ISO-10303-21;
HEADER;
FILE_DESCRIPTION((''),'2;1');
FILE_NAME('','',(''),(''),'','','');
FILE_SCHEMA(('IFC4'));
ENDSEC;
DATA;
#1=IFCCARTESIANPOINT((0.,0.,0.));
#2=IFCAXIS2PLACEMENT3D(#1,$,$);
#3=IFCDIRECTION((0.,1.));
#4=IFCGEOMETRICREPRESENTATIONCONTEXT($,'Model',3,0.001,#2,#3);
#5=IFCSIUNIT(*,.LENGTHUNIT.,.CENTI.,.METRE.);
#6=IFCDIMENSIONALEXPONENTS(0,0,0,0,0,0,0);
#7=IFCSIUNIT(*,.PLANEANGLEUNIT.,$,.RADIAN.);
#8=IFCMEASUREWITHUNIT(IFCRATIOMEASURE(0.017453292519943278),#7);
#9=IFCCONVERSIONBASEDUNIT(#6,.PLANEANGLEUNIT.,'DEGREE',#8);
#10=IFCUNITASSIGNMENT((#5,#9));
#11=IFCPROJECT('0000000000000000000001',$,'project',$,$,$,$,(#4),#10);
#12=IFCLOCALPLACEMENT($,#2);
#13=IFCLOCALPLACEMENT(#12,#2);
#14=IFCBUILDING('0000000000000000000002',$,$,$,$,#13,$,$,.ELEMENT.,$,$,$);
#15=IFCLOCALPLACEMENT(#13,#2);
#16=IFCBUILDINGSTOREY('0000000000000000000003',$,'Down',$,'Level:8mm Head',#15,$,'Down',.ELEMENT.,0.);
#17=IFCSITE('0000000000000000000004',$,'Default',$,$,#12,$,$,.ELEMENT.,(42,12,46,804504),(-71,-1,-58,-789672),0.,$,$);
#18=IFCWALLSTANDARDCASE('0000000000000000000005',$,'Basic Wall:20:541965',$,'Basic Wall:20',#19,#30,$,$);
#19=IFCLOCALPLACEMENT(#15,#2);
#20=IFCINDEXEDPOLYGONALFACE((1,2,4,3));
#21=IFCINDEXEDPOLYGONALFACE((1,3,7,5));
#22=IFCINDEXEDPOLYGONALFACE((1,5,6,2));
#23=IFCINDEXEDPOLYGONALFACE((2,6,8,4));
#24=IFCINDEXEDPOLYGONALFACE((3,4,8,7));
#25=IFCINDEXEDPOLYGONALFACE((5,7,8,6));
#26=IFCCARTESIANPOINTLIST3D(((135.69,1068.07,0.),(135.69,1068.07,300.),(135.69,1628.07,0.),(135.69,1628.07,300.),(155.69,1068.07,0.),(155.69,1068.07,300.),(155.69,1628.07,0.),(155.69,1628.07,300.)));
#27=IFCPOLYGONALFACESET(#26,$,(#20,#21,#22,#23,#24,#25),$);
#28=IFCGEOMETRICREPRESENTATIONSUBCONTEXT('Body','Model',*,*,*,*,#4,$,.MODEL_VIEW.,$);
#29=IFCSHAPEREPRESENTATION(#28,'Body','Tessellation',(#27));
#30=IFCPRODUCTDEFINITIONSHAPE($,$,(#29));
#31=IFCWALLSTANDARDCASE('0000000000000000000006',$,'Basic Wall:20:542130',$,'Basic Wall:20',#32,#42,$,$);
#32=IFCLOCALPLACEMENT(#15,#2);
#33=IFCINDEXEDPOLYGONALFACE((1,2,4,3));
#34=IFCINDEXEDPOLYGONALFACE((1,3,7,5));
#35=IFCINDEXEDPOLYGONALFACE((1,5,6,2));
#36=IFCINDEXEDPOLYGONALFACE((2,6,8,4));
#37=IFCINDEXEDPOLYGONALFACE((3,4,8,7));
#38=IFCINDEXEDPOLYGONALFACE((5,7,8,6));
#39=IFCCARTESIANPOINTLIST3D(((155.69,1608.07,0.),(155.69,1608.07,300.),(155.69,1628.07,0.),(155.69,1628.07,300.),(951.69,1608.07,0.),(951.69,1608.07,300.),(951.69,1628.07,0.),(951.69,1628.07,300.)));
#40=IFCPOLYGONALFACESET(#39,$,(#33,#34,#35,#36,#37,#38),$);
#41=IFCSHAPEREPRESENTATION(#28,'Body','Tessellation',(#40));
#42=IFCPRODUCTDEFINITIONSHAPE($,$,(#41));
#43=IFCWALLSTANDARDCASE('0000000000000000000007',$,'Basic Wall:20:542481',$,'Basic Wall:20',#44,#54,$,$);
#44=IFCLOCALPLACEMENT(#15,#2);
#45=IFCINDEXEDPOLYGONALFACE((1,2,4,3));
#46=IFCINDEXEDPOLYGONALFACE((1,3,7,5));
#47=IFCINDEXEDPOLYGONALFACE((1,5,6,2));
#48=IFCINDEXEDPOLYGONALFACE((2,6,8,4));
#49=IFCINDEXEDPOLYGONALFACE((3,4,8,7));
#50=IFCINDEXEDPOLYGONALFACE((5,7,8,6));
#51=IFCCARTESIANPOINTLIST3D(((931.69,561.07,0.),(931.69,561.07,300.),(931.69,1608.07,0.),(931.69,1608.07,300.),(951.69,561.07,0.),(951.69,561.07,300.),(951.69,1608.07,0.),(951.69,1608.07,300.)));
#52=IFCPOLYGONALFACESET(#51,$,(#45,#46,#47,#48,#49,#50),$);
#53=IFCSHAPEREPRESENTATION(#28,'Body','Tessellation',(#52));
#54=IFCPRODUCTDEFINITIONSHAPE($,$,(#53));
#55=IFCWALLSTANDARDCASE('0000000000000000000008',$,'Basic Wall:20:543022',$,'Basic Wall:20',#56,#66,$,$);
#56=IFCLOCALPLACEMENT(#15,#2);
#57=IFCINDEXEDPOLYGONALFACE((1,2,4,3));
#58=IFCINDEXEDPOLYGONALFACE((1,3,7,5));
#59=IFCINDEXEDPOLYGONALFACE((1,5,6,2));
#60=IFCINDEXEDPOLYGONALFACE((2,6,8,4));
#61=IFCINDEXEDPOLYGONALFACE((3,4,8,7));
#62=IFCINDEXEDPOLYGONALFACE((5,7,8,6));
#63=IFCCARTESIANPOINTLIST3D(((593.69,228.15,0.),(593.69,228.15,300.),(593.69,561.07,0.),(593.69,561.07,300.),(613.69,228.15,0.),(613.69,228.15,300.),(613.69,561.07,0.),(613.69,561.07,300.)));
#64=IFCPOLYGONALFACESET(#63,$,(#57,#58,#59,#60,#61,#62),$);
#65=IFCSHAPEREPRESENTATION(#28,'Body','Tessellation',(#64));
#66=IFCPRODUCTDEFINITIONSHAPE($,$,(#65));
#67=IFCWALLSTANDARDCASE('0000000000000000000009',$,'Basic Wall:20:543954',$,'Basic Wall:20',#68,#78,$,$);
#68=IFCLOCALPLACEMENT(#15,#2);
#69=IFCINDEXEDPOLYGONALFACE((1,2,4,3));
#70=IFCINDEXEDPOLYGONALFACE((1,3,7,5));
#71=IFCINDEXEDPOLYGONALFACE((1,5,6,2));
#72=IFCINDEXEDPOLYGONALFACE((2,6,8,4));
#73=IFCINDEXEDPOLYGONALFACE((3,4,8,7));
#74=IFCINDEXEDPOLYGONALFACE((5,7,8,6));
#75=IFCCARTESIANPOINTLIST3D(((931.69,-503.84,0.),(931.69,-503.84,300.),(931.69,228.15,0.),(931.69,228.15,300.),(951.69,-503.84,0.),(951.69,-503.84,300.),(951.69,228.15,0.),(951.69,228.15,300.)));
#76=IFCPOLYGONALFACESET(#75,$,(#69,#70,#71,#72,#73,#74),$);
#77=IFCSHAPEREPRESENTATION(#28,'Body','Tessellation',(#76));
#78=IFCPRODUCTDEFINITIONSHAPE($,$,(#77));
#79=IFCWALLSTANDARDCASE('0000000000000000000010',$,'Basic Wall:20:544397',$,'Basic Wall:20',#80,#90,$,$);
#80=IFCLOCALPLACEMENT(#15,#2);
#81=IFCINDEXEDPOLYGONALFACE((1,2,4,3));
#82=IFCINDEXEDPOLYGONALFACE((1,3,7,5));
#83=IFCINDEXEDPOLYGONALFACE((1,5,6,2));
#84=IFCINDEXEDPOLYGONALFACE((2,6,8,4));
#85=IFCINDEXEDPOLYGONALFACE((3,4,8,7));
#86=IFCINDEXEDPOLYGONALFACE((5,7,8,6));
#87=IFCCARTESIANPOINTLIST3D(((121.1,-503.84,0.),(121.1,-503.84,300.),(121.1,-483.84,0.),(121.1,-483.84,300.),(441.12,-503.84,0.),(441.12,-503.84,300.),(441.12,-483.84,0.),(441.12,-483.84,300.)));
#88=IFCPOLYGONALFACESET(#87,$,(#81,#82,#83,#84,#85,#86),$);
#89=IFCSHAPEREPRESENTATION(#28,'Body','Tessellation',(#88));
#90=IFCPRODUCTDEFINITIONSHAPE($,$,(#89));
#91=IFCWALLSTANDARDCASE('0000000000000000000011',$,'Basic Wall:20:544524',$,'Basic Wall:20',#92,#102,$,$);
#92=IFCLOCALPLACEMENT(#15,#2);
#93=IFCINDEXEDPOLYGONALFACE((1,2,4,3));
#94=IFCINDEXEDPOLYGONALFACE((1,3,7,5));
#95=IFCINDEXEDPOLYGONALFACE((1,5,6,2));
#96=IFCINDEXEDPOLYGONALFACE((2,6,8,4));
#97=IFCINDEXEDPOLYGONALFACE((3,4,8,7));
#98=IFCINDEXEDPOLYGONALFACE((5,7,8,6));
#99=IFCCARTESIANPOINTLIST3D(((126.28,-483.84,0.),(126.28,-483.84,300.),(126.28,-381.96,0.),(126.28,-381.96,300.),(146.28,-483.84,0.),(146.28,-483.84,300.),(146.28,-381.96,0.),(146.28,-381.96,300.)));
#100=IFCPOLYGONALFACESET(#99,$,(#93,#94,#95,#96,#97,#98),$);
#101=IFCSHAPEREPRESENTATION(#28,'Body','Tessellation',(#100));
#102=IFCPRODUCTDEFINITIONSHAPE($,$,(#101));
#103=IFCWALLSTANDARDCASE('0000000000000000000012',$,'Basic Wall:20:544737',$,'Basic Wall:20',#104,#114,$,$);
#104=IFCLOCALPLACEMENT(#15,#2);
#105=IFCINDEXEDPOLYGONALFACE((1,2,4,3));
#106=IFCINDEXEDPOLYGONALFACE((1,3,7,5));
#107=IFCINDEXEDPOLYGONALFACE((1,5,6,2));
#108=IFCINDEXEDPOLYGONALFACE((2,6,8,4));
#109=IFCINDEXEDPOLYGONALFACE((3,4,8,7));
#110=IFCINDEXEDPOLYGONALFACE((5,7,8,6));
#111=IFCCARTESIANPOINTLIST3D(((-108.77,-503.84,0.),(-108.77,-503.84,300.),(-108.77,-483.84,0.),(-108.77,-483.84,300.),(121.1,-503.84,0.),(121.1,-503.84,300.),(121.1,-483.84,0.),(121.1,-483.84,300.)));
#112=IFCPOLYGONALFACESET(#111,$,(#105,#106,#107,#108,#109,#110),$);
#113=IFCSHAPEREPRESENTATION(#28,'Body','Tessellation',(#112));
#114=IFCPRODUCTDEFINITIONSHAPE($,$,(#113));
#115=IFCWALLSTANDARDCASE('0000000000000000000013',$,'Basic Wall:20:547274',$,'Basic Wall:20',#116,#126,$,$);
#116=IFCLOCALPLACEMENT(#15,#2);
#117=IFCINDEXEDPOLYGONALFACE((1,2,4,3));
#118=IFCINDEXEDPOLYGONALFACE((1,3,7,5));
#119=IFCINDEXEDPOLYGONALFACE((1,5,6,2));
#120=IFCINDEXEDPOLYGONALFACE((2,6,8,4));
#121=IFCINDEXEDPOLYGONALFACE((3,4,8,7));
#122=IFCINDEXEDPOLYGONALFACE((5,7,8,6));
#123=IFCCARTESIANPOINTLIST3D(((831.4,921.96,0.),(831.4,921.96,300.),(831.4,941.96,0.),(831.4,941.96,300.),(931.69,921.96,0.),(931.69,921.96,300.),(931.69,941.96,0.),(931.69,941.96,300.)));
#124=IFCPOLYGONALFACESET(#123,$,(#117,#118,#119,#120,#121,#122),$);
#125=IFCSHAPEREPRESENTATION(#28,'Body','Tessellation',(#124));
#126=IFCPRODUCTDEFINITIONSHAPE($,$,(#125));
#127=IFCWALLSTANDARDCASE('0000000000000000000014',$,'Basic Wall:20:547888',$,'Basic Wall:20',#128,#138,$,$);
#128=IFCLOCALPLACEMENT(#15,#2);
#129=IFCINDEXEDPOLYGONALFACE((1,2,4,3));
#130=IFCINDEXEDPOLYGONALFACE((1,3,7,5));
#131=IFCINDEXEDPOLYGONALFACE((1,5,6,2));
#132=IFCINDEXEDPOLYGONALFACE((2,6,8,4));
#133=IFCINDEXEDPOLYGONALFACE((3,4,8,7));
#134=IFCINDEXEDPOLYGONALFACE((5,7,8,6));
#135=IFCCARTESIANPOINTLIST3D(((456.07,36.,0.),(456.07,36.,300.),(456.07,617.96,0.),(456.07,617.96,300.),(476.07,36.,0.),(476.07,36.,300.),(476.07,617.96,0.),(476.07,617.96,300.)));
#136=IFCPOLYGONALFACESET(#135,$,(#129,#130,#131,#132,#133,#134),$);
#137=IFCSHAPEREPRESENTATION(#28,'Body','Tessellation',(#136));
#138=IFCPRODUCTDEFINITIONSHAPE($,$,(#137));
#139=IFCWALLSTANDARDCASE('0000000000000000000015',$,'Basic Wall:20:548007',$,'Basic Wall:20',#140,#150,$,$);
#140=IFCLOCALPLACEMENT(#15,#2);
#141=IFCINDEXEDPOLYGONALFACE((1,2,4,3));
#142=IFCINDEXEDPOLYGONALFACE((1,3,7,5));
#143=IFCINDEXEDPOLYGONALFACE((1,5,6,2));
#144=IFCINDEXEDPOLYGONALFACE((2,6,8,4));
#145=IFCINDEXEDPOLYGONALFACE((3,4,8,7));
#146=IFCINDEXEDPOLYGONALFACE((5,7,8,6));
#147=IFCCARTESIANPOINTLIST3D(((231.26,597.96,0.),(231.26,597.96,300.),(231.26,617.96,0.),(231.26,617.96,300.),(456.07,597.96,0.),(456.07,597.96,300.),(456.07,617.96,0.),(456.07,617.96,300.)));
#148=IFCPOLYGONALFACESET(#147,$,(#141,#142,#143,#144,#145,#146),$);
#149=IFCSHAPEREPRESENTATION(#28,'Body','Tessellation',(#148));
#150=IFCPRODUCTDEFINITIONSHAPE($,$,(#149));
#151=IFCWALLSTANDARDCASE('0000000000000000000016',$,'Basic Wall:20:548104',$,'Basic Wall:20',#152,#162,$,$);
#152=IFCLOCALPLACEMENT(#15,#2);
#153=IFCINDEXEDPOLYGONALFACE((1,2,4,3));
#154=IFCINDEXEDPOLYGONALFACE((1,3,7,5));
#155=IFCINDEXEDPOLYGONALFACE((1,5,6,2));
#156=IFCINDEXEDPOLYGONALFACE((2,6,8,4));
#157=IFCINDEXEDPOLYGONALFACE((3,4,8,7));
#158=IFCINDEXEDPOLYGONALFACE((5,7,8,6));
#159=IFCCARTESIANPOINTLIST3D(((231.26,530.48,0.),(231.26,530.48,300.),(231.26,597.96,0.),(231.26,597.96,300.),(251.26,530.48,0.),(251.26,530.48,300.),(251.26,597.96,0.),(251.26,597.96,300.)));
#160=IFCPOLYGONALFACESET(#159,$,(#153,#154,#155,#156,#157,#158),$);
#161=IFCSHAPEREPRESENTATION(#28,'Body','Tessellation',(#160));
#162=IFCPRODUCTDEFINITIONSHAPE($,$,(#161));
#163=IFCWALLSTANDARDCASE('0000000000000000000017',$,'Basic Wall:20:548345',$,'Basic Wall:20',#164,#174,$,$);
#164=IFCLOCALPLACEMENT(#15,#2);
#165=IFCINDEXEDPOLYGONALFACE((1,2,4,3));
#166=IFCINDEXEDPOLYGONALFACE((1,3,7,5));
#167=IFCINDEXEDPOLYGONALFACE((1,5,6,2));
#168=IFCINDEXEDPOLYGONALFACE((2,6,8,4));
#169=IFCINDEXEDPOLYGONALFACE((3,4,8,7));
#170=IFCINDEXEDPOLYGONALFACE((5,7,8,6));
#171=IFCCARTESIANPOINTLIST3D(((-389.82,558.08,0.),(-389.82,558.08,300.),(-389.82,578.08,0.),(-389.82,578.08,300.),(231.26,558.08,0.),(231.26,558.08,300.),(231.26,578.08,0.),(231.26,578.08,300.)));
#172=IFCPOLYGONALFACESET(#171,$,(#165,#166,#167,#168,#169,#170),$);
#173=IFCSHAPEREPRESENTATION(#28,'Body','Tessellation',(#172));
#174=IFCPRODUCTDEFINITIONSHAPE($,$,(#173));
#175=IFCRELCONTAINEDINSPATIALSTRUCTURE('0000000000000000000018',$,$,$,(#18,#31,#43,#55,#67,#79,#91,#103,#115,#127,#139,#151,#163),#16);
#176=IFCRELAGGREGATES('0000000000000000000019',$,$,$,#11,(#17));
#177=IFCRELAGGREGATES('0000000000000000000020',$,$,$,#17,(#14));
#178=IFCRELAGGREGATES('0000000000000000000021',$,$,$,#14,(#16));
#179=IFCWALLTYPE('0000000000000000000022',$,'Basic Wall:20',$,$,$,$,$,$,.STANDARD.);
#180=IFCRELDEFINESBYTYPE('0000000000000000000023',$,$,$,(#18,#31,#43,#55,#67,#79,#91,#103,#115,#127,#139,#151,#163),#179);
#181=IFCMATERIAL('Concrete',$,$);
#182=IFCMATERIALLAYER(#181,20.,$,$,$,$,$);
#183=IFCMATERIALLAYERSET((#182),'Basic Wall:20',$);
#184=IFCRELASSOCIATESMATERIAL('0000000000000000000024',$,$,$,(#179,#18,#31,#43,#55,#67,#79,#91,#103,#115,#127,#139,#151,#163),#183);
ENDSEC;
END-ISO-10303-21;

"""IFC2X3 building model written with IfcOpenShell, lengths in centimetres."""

from ifc_helpers import new_model, entity, si_unit, converted_unit, direction, frame, frame_2d, origin, place, context, subcontext, project, spatial, rectangle, extrude, material, layer, layer_set, layer_usage, type_object, element, save


model = new_model("IFC2X3")

# Units and contexts
model_context = context("Model", 3, precision=0.001, world=origin(), true_north=direction((0.0, 1.0)))
body_context = subcontext(model_context, "Body", "Model", "MODEL_VIEW")
ifc_project = project(units=[si_unit("LENGTHUNIT", "METRE", prefix="CENTI"), converted_unit("PLANEANGLEUNIT", "DEGREE", entity("IfcRatioMeasure", 0.017453292519943278), si_unit("PLANEANGLEUNIT", "RADIAN"), dimensions=[0, 0, 0, 0, 0, 0, 0])], contexts=[model_context])

# Site, building, storey
site_placement = place(None, origin())
site = spatial("IfcSite", under=ifc_project, at=site_placement, Name="Default", CompositionType="ELEMENT", RefLatitude=(42, 12, 46, 804504), RefLongitude=(-71, -1, -58, -789672), RefElevation=0.0)
building_placement = place(site_placement, origin())
building = spatial("IfcBuilding", under=site, at=building_placement, CompositionType="ELEMENT")
storey_placement = place(building_placement, origin())
storey = spatial("IfcBuildingStorey", under=building, at=storey_placement, Name="Down", ObjectType="Level:8mm Head", LongName="Down", CompositionType="ELEMENT", Elevation=0.0)

# Walls
ifc_material = material(Name="Concrete")
ifc_layer_1 = layer(ifc_material, 20.0)
ifc_layer_set_1 = layer_set([ifc_layer_1], Name="Basic Wall:20")
ifc_layer_usage_1 = layer_usage(ifc_layer_set_1, "AXIS2", "POSITIVE", -10.0)
wall_type_1 = type_object("IfcWallType", Name="Basic Wall:20", PredefinedType="STANDARD", material=ifc_layer_set_1)
wall_1_placement = place(storey_placement, frame((145.69, 1068.07, 0.0), z_axis=(0.0, 0.0, 1.0), x_axis=(0.0, 1.0, 0.0)))
element("IfcWallStandardCase", 1, at=wall_1_placement, inside=storey, type_object=wall_type_1, material=ifc_layer_usage_1, Name="Basic Wall:20:541965", ObjectType="Basic Wall:20", context=body_context, shape_type="SweptSolid", body=[
    extrude(rectangle(XDim=560.0, YDim=20.0, at=frame_2d((280.0, 0.0), x_axis=(-1.0, 0.0))), origin(), (0.0, 0.0, 1.0), 300.0),
])
ifc_layer_usage_2 = layer_usage(ifc_layer_set_1, "AXIS2", "NEGATIVE", 10.0)
wall_2_placement = place(storey_placement, frame((155.69, 1618.07, 0.0)))
element("IfcWallStandardCase", 2, at=wall_2_placement, inside=storey, type_object=wall_type_1, material=ifc_layer_usage_2, Name="Basic Wall:20:542130", ObjectType="Basic Wall:20", context=body_context, shape_type="SweptSolid", body=[
    extrude(rectangle(XDim=796.0, YDim=20.0, at=frame_2d((398.0, 0.0), x_axis=(-1.0, 0.0))), origin(), (0.0, 0.0, 1.0), 300.0),
])
ifc_layer_usage_3 = layer_usage(ifc_layer_set_1, "AXIS2", "NEGATIVE", 10.0)
wall_3_placement = place(storey_placement, frame((941.69, 1608.07, 0.0), z_axis=(0.0, 0.0, 1.0), x_axis=(0.0, -1.0, 0.0)))
element("IfcWallStandardCase", 3, at=wall_3_placement, inside=storey, type_object=wall_type_1, material=ifc_layer_usage_3, Name="Basic Wall:20:542481", ObjectType="Basic Wall:20", context=body_context, shape_type="SweptSolid", body=[
    extrude(rectangle(XDim=1047.0, YDim=20.0, at=frame_2d((523.5, 0.0), x_axis=(-1.0, 0.0))), origin(), (0.0, 0.0, 1.0), 300.0),
])
ifc_layer_usage_4 = layer_usage(ifc_layer_set_1, "AXIS2", "POSITIVE", -10.0)
wall_4_placement = place(storey_placement, frame((603.69, 561.07, 0.0), z_axis=(0.0, 0.0, 1.0), x_axis=(0.0, -1.0, 0.0)))
element("IfcWallStandardCase", 4, at=wall_4_placement, inside=storey, type_object=wall_type_1, material=ifc_layer_usage_4, Name="Basic Wall:20:543022", ObjectType="Basic Wall:20", context=body_context, shape_type="SweptSolid", body=[
    extrude(rectangle(XDim=332.91, YDim=20.0, at=frame_2d((166.46, 0.0), x_axis=(-1.0, 0.0))), origin(), (0.0, 0.0, 1.0), 300.0),
])
ifc_layer_usage_5 = layer_usage(ifc_layer_set_1, "AXIS2", "NEGATIVE", 10.0)
wall_5_placement = place(storey_placement, frame((941.69, 228.15, 0.0), z_axis=(0.0, 0.0, 1.0), x_axis=(0.0, -1.0, 0.0)))
element("IfcWallStandardCase", 5, at=wall_5_placement, inside=storey, type_object=wall_type_1, material=ifc_layer_usage_5, Name="Basic Wall:20:543954", ObjectType="Basic Wall:20", context=body_context, shape_type="SweptSolid", body=[
    extrude(rectangle(XDim=732.0, YDim=20.0, at=frame_2d((366.0, 0.0), x_axis=(-1.0, 0.0))), origin(), (0.0, 0.0, 1.0), 300.0),
])
ifc_layer_usage_6 = layer_usage(ifc_layer_set_1, "AXIS2", "NEGATIVE", 10.0)
wall_6_placement = place(storey_placement, frame((441.12, -493.84, 0.0), z_axis=(0.0, 0.0, 1.0), x_axis=(-1.0, 0.0, 0.0)))
element("IfcWallStandardCase", 6, at=wall_6_placement, inside=storey, type_object=wall_type_1, material=ifc_layer_usage_6, Name="Basic Wall:20:544397", ObjectType="Basic Wall:20", context=body_context, shape_type="SweptSolid", body=[
    extrude(rectangle(XDim=320.02, YDim=20.0, at=frame_2d((160.01, 0.0), x_axis=(-1.0, 0.0))), origin(), (0.0, 0.0, 1.0), 300.0),
])
ifc_layer_usage_7 = layer_usage(ifc_layer_set_1, "AXIS2", "POSITIVE", -10.0)
wall_7_placement = place(storey_placement, frame((136.28, -483.84, 0.0), z_axis=(0.0, 0.0, 1.0), x_axis=(0.0, 1.0, 0.0)))
element("IfcWallStandardCase", 7, at=wall_7_placement, inside=storey, type_object=wall_type_1, material=ifc_layer_usage_7, Name="Basic Wall:20:544524", ObjectType="Basic Wall:20", context=body_context, shape_type="SweptSolid", body=[
    extrude(rectangle(XDim=101.88, YDim=20.0, at=frame_2d((50.94, 0.0), x_axis=(-1.0, 0.0))), origin(), (0.0, 0.0, 1.0), 300.0),
])
ifc_layer_usage_8 = layer_usage(ifc_layer_set_1, "AXIS2", "POSITIVE", -10.0)
wall_8_placement = place(storey_placement, frame((121.1, -493.84, 0.0), z_axis=(0.0, 0.0, 1.0), x_axis=(-1.0, 0.0, 0.0)))
element("IfcWallStandardCase", 8, at=wall_8_placement, inside=storey, type_object=wall_type_1, material=ifc_layer_usage_8, Name="Basic Wall:20:544737", ObjectType="Basic Wall:20", context=body_context, shape_type="SweptSolid", body=[
    extrude(rectangle(XDim=229.87, YDim=20.0, at=frame_2d((114.93, 0.0), x_axis=(-1.0, 0.0))), origin(), (0.0, 0.0, 1.0), 300.0),
])
ifc_layer_usage_9 = layer_usage(ifc_layer_set_1, "AXIS2", "POSITIVE", -10.0)
wall_9_placement = place(storey_placement, frame((931.69, 931.96, 0.0), z_axis=(0.0, 0.0, 1.0), x_axis=(-1.0, 0.0, 0.0)))
element("IfcWallStandardCase", 9, at=wall_9_placement, inside=storey, type_object=wall_type_1, material=ifc_layer_usage_9, Name="Basic Wall:20:547274", ObjectType="Basic Wall:20", context=body_context, shape_type="SweptSolid", body=[
    extrude(rectangle(XDim=100.29, YDim=20.0, at=frame_2d((50.15, 0.0), x_axis=(-1.0, 0.0))), origin(), (0.0, 0.0, 1.0), 300.0),
])
ifc_layer_usage_10 = layer_usage(ifc_layer_set_1, "AXIS2", "NEGATIVE", 10.0)
wall_10_placement = place(storey_placement, frame((466.07, 36.0, 0.0), z_axis=(0.0, 0.0, 1.0), x_axis=(0.0, 1.0, 0.0)))
element("IfcWallStandardCase", 10, at=wall_10_placement, inside=storey, type_object=wall_type_1, material=ifc_layer_usage_10, Name="Basic Wall:20:547888", ObjectType="Basic Wall:20", context=body_context, shape_type="SweptSolid", body=[
    extrude(rectangle(XDim=581.96, YDim=20.0, at=frame_2d((290.98, 0.0), x_axis=(-1.0, 0.0))), origin(), (0.0, 0.0, 1.0), 300.0),
])
ifc_layer_usage_11 = layer_usage(ifc_layer_set_1, "AXIS2", "POSITIVE", -10.0)
wall_11_placement = place(storey_placement, frame((456.07, 607.96, 0.0), z_axis=(0.0, 0.0, 1.0), x_axis=(-1.0, 0.0, 0.0)))
element("IfcWallStandardCase", 11, at=wall_11_placement, inside=storey, type_object=wall_type_1, material=ifc_layer_usage_11, Name="Basic Wall:20:548007", ObjectType="Basic Wall:20", context=body_context, shape_type="SweptSolid", body=[
    extrude(rectangle(XDim=224.8, YDim=20.0, at=frame_2d((112.4, 0.0), x_axis=(-1.0, 0.0))), origin(), (0.0, 0.0, 1.0), 300.0),
])
ifc_layer_usage_12 = layer_usage(ifc_layer_set_1, "AXIS2", "POSITIVE", -10.0)
wall_12_placement = place(storey_placement, frame((241.26, 597.96, 0.0), z_axis=(0.0, 0.0, 1.0), x_axis=(0.0, -1.0, 0.0)))
element("IfcWallStandardCase", 12, at=wall_12_placement, inside=storey, type_object=wall_type_1, material=ifc_layer_usage_12, Name="Basic Wall:20:548104", ObjectType="Basic Wall:20", context=body_context, shape_type="SweptSolid", body=[
    extrude(rectangle(XDim=67.48, YDim=20.0, at=frame_2d((33.74, 0.0), x_axis=(-1.0, 0.0))), origin(), (0.0, 0.0, 1.0), 300.0),
])
ifc_layer_usage_13 = layer_usage(ifc_layer_set_1, "AXIS2", "POSITIVE", -10.0)
wall_13_placement = place(storey_placement, frame((231.26, 568.08, 0.0), z_axis=(0.0, 0.0, 1.0), x_axis=(-1.0, 0.0, 0.0)))
element("IfcWallStandardCase", 13, at=wall_13_placement, inside=storey, type_object=wall_type_1, material=ifc_layer_usage_13, Name="Basic Wall:20:548345", ObjectType="Basic Wall:20", context=body_context, shape_type="SweptSolid", body=[
    extrude(rectangle(XDim=621.09, YDim=20.0, at=frame_2d((310.54, 0.0), x_axis=(-1.0, 0.0))), origin(), (0.0, 0.0, 1.0), 300.0),
])

save(model, "model.ifc")
